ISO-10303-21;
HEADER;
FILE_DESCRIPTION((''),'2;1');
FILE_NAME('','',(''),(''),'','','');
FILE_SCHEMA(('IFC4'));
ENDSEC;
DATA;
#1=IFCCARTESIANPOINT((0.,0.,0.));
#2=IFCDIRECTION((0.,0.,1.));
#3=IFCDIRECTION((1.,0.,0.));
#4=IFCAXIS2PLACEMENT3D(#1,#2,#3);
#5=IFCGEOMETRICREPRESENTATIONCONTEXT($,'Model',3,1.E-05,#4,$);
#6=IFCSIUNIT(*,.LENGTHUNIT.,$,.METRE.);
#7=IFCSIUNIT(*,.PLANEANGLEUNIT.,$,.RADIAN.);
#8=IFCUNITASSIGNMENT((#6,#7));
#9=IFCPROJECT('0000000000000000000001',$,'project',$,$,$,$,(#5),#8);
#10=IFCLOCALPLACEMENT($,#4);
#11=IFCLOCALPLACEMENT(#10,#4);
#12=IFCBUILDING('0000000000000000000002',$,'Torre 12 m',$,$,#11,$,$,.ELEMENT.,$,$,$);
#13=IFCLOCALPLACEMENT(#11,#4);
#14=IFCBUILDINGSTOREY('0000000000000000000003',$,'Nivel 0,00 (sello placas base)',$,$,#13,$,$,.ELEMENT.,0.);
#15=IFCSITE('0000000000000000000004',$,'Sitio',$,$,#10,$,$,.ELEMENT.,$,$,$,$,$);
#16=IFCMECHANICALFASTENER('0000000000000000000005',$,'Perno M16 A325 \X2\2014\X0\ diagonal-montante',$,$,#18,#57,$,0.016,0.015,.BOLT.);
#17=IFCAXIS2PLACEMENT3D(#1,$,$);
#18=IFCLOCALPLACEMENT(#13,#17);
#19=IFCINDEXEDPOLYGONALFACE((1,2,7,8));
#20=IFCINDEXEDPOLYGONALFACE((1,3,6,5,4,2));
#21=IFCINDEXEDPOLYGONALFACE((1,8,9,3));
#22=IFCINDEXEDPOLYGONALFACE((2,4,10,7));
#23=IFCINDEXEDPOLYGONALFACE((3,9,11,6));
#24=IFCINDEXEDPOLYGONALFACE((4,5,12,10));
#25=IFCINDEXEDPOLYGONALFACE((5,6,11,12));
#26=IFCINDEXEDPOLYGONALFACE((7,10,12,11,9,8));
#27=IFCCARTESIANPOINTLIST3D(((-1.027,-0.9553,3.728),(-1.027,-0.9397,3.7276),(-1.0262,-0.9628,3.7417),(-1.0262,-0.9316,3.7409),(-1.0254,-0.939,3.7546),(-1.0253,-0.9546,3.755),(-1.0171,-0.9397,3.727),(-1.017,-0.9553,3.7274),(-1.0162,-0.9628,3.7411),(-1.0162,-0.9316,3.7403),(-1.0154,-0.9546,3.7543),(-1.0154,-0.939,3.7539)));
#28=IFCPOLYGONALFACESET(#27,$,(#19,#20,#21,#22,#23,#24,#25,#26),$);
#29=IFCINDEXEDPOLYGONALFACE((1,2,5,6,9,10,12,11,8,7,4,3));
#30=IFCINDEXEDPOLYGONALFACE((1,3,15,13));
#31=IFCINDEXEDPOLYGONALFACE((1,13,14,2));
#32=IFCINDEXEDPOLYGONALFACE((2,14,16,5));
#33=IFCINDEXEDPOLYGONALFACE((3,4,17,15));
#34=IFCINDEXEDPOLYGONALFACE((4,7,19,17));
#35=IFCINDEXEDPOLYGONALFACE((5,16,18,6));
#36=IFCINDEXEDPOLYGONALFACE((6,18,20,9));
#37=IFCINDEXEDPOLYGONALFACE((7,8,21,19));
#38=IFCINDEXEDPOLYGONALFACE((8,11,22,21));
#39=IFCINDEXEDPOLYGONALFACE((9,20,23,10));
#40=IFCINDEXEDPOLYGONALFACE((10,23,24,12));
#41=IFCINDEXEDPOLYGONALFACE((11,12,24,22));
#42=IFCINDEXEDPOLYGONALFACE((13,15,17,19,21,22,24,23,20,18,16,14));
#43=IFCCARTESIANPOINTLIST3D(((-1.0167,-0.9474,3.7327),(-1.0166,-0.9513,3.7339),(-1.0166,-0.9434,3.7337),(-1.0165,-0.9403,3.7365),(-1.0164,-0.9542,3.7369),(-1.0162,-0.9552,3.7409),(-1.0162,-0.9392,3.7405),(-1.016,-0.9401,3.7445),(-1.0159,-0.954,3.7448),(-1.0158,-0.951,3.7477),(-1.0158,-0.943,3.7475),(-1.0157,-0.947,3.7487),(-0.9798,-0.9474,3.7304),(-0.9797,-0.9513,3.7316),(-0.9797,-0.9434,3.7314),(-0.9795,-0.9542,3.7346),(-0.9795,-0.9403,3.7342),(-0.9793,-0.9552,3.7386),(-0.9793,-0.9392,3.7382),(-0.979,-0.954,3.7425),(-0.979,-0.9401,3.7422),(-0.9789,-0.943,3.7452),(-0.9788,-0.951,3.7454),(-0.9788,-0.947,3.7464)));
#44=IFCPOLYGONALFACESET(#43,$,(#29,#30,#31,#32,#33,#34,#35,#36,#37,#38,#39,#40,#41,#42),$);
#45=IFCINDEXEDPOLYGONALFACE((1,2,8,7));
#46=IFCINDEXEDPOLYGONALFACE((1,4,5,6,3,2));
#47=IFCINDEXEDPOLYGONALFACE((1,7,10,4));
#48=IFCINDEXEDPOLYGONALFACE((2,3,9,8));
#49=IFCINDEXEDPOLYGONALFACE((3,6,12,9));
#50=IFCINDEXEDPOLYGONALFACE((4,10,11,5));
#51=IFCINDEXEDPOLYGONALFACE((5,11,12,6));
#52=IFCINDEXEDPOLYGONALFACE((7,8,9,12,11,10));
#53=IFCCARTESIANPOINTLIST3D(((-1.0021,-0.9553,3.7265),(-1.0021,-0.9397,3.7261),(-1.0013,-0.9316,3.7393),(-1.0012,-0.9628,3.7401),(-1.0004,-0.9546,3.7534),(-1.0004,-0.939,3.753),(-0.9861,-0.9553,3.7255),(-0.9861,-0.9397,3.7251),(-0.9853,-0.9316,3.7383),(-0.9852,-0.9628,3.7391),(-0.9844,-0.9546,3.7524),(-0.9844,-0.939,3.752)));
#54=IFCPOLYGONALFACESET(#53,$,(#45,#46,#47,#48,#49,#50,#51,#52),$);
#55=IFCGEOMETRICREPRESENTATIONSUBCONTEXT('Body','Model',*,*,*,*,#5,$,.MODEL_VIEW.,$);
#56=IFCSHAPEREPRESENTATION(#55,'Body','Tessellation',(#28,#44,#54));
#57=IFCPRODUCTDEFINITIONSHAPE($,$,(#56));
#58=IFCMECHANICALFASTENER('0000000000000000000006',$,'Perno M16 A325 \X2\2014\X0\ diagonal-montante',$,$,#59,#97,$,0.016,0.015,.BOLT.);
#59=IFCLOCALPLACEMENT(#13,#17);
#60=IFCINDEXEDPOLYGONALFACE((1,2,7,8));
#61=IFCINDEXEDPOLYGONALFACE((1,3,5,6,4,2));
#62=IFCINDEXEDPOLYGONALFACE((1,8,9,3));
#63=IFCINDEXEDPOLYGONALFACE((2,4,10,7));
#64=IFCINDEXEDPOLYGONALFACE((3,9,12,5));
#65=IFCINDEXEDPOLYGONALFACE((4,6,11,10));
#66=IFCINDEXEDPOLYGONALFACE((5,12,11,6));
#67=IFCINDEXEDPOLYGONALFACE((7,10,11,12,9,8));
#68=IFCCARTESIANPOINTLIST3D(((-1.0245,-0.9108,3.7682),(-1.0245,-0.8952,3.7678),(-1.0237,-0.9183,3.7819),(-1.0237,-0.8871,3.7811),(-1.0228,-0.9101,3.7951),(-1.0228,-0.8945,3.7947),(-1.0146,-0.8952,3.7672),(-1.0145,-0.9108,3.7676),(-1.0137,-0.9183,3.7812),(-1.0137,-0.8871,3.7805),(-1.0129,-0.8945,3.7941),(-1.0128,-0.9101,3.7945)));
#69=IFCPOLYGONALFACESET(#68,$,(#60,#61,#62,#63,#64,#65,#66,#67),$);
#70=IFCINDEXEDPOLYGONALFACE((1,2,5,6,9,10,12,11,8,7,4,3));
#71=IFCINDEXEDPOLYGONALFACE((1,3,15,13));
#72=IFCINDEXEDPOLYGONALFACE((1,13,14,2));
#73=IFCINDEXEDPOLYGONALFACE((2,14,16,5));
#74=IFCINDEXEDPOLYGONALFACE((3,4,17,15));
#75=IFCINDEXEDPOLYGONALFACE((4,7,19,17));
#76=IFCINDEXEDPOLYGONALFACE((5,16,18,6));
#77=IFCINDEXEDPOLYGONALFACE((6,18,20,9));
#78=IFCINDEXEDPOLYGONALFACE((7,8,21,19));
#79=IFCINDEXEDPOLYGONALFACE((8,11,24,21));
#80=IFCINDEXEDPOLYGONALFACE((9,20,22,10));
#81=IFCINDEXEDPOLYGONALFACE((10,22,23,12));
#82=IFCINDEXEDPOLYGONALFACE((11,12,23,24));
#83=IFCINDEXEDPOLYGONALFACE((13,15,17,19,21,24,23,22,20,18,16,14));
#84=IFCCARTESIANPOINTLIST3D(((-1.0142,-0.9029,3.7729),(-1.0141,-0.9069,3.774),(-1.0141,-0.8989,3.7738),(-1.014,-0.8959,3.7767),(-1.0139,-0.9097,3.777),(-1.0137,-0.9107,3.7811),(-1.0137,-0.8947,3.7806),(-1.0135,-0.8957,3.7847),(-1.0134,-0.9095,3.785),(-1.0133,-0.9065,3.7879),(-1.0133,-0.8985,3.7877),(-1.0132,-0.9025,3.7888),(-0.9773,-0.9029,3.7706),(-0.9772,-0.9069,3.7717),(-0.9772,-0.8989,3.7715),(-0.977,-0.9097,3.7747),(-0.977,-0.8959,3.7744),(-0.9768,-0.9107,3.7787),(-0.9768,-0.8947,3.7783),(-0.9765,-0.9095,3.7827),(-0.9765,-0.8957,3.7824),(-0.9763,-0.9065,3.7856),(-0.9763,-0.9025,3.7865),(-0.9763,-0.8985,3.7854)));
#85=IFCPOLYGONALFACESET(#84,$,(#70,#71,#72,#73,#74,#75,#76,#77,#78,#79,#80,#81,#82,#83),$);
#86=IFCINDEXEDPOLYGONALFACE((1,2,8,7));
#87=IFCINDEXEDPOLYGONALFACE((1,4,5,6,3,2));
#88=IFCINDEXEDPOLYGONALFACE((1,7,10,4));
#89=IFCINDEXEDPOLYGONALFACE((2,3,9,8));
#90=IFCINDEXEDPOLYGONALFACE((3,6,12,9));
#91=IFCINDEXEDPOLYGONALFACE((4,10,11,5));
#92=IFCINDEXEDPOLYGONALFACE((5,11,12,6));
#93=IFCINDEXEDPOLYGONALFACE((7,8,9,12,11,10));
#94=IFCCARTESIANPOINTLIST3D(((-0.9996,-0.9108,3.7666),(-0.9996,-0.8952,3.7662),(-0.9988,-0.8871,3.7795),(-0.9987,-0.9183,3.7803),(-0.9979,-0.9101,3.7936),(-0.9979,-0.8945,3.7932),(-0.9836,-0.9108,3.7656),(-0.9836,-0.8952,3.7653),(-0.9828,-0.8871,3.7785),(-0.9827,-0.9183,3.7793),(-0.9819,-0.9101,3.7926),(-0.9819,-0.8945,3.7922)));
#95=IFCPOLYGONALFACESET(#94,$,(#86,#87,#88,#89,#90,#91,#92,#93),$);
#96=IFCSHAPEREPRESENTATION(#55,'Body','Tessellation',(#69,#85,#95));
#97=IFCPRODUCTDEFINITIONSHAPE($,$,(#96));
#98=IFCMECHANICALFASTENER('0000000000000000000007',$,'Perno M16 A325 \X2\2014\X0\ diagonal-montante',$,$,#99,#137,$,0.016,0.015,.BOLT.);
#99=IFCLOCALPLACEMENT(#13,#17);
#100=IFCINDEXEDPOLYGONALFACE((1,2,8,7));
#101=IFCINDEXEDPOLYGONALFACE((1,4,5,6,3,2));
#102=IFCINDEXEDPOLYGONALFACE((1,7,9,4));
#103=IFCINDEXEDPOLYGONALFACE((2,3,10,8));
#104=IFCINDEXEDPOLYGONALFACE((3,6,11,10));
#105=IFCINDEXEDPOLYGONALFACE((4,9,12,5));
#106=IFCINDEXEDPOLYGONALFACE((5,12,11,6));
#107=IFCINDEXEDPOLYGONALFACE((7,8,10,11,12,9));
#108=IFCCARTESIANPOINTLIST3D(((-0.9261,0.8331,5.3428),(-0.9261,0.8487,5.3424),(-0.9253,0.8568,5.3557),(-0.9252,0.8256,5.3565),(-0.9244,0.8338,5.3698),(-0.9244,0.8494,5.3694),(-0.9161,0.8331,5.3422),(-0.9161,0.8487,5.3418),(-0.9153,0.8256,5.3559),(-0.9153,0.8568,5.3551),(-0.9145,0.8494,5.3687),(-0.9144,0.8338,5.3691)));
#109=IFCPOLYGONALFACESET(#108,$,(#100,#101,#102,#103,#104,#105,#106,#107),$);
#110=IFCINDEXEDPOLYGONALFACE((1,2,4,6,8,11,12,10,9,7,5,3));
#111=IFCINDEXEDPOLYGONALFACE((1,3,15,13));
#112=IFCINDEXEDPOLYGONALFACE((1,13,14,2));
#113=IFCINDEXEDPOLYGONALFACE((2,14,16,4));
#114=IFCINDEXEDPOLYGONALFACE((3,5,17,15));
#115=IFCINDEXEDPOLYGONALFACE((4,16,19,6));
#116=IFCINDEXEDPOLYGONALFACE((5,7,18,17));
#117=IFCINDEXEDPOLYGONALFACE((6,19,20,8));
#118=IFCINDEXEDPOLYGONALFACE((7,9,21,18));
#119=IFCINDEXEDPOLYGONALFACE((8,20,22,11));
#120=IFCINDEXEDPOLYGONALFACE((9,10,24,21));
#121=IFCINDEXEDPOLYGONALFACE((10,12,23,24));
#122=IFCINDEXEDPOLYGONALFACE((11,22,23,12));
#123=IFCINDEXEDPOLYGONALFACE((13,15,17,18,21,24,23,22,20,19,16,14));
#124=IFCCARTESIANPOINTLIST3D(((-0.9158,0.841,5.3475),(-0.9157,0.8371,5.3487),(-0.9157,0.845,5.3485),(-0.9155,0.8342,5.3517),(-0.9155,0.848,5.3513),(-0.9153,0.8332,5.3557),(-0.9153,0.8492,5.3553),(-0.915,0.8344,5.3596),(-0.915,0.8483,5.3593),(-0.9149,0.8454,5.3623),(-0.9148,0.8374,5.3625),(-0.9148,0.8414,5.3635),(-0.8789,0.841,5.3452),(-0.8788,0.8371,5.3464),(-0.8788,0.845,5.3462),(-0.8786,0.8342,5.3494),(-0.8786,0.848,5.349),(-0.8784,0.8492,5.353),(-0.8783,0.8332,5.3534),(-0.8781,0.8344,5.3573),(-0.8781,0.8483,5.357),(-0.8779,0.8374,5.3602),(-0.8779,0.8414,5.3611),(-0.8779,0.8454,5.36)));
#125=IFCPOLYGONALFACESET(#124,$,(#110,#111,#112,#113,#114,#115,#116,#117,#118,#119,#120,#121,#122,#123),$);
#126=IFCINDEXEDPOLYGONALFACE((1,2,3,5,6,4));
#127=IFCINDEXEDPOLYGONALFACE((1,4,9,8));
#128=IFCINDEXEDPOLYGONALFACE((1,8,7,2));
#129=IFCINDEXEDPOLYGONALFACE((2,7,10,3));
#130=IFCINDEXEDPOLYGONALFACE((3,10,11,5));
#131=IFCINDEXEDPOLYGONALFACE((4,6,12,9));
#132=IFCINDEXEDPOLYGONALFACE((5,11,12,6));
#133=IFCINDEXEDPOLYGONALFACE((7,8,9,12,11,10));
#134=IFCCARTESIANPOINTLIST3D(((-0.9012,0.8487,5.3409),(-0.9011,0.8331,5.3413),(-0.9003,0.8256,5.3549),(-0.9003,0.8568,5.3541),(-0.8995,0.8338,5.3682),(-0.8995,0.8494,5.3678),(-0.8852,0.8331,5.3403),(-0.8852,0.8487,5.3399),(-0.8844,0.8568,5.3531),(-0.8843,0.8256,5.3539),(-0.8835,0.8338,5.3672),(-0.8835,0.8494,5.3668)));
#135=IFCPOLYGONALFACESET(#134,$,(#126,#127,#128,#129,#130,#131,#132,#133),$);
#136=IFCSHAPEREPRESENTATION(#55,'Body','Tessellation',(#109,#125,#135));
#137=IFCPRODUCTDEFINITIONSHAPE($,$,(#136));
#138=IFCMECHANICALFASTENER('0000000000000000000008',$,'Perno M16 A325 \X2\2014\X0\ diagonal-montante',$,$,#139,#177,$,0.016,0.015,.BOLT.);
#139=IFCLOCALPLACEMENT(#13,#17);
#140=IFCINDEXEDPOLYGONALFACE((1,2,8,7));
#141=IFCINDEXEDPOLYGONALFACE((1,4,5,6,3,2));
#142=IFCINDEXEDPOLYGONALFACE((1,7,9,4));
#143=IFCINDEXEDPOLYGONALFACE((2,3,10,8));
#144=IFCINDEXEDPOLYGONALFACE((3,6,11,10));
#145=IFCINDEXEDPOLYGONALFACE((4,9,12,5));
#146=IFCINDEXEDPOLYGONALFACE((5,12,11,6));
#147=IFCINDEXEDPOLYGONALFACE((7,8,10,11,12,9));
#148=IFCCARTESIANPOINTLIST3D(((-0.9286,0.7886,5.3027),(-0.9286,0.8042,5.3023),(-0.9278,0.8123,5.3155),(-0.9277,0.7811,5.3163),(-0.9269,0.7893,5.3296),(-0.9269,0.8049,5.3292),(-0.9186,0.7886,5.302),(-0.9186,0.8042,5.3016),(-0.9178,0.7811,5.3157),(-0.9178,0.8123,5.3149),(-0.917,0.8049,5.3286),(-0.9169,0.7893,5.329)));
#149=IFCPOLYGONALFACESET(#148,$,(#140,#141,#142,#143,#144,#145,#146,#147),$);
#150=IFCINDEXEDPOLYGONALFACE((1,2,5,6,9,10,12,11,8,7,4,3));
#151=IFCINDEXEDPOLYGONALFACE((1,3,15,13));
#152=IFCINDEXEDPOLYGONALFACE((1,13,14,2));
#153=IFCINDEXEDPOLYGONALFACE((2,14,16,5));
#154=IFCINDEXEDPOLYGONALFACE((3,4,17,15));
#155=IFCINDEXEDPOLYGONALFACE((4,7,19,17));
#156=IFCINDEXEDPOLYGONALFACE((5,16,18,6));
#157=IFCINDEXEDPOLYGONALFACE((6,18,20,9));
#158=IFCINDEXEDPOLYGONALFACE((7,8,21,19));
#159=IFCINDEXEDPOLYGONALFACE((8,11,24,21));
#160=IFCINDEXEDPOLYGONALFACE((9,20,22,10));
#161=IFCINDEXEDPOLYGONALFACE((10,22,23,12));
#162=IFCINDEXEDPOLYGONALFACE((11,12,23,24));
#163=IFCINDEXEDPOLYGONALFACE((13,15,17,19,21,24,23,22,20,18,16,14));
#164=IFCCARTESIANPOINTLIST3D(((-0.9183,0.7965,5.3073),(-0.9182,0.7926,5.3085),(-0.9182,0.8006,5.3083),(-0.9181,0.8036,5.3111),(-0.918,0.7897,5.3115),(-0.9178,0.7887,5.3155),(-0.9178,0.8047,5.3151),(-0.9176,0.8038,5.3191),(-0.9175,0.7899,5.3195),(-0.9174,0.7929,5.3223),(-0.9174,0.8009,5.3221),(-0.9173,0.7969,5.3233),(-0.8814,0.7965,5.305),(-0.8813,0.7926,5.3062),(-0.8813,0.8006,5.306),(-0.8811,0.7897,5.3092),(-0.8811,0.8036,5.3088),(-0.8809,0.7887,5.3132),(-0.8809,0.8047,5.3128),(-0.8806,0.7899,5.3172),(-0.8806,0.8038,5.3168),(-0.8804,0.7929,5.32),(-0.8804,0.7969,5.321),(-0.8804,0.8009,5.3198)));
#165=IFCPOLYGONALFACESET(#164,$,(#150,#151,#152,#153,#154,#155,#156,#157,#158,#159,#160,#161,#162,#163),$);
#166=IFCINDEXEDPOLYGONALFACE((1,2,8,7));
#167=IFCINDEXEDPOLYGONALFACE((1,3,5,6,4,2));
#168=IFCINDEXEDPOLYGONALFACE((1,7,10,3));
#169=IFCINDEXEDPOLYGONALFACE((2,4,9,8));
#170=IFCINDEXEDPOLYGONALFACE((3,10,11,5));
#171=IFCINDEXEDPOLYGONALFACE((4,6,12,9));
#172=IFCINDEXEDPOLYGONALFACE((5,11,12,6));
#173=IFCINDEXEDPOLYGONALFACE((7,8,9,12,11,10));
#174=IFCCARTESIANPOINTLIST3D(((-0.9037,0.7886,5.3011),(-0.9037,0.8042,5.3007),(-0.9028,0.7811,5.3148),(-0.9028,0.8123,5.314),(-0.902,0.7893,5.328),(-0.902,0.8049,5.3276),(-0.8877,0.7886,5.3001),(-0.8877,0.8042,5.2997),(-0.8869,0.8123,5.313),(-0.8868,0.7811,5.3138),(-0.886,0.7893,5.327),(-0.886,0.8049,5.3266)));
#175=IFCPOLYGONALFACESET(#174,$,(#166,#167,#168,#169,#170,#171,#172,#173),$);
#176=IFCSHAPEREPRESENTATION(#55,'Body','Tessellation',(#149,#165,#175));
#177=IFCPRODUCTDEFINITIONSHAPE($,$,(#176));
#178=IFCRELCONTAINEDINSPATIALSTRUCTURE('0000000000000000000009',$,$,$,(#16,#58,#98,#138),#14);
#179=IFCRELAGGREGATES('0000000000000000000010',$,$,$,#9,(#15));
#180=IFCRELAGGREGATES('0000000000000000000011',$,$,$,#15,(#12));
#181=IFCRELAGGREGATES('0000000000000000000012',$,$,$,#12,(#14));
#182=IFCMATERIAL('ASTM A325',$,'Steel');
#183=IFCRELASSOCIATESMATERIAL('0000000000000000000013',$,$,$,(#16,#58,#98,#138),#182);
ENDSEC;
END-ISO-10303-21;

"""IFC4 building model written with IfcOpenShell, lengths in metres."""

from ifc_helpers import new_model, si_unit, frame, origin_with_axes, place, context, subcontext, project, spatial, polyline, outline, extrude, material, element, save


model = new_model("IFC4")

# Units and contexts
model_context = context("Model", 3, precision=1e-05, world=origin_with_axes())
body_context = subcontext(model_context, "Body", "Model", "MODEL_VIEW")
ifc_project = project(units=[si_unit("LENGTHUNIT", "METRE"), si_unit("PLANEANGLEUNIT", "RADIAN")], contexts=[model_context])

# Site, building, storey
site_placement = place(None, origin_with_axes())
site = spatial("IfcSite", under=ifc_project, at=site_placement, Name="Sitio", CompositionType="ELEMENT")
building_placement = place(site_placement, origin_with_axes())
building = spatial("IfcBuilding", under=site, at=building_placement, Name="Torre 12 m", CompositionType="ELEMENT")
storey_placement = place(building_placement, origin_with_axes())
storey = spatial("IfcBuildingStorey", under=building, at=storey_placement, Name="Nivel 0,00 (sello placas base)", CompositionType="ELEMENT", Elevation=0.0)

# Shared definitions
placement = place(storey_placement, origin_with_axes())

# Mechanical fasteners
ifc_material_1 = material(Name="ASTM A325", Category="Steel")
element("IfcMechanicalFastener", 1, at=placement, inside=storey, material=ifc_material_1, Name="Perno M16 A325 — diagonal-montante", NominalDiameter=0.016, NominalLength=0.015, PredefinedType="BOLT", context=body_context, shape_type="SweptSolid", body=[
    extrude(outline(polyline([(0.0135, 0.0078), (0.0, 0.0156), (-0.0135, 0.0078), (-0.0135, -0.0078), (0.0, -0.0156), (0.0135, -0.0078), (0.0135, 0.0078)])), frame((-1.0262, -0.9472, 3.7413), z_axis=(0.998053, 0.0, -0.062378), x_axis=(0.032557, -0.85299, 0.52091)), (0.0, 0.0, 1.0), 0.01),
    extrude(outline(polyline([(0.008, 0.0), (0.0069, 0.004), (0.004, 0.0069), (0.0, 0.008), (-0.004, 0.0069), (-0.0069, 0.004), (-0.008, 0.0), (-0.0069, -0.004), (-0.004, -0.0069), (0.0, -0.008), (0.004, -0.0069), (0.0069, -0.004), (0.008, 0.0)])), frame((-1.0162, -0.9472, 3.7407), z_axis=(0.998053, 0.0, -0.062378), x_axis=(0.032557, -0.85299, 0.52091)), (0.0, 0.0, 1.0), 0.037),
    extrude(outline(polyline([(0.0135, 0.0078), (0.0, 0.0156), (-0.0135, 0.0078), (-0.0135, -0.0078), (0.0, -0.0156), (0.0135, -0.0078), (0.0135, 0.0078)])), frame((-1.0012, -0.9472, 3.7397), z_axis=(0.998053, 0.0, -0.062378), x_axis=(0.032557, -0.85299, 0.52091)), (0.0, 0.0, 1.0), 0.016),
])
element("IfcMechanicalFastener", 2, at=placement, inside=storey, material=ifc_material_1, Name="Perno M16 A325 — diagonal-montante", NominalDiameter=0.016, NominalLength=0.015, PredefinedType="BOLT", context=body_context, shape_type="SweptSolid", body=[
    extrude(outline(polyline([(0.0135, 0.0078), (0.0, 0.0156), (-0.0135, 0.0078), (-0.0135, -0.0078), (0.0, -0.0156), (0.0135, -0.0078), (0.0135, 0.0078)])), frame((-1.0237, -0.9027, 3.7815), z_axis=(0.998053, 0.0, -0.062378), x_axis=(0.032557, -0.85299, 0.52091)), (0.0, 0.0, 1.0), 0.01),
    extrude(outline(polyline([(0.008, 0.0), (0.0069, 0.004), (0.004, 0.0069), (0.0, 0.008), (-0.004, 0.0069), (-0.0069, 0.004), (-0.008, 0.0), (-0.0069, -0.004), (-0.004, -0.0069), (0.0, -0.008), (0.004, -0.0069), (0.0069, -0.004), (0.008, 0.0)])), frame((-1.0137, -0.9027, 3.7809), z_axis=(0.998053, 0.0, -0.062378), x_axis=(0.032557, -0.85299, 0.52091)), (0.0, 0.0, 1.0), 0.037),
    extrude(outline(polyline([(0.0135, 0.0078), (0.0, 0.0156), (-0.0135, 0.0078), (-0.0135, -0.0078), (0.0, -0.0156), (0.0135, -0.0078), (0.0135, 0.0078)])), frame((-0.9987, -0.9027, 3.7799), z_axis=(0.998053, 0.0, -0.062378), x_axis=(0.032557, -0.85299, 0.52091)), (0.0, 0.0, 1.0), 0.016),
])
element("IfcMechanicalFastener", 3, at=placement, inside=storey, material=ifc_material_1, Name="Perno M16 A325 — diagonal-montante", NominalDiameter=0.016, NominalLength=0.015, PredefinedType="BOLT", context=body_context, shape_type="SweptSolid", body=[
    extrude(outline(polyline([(0.0135, 0.0078), (0.0, 0.0156), (-0.0135, 0.0078), (-0.0135, -0.0078), (0.0, -0.0156), (0.0135, -0.0078), (0.0135, 0.0078)])), frame((-0.9253, 0.8412, 5.3561), z_axis=(0.998053, 0.0, -0.062378), x_axis=(0.032557, -0.85299, 0.52091)), (0.0, 0.0, 1.0), 0.01),
    extrude(outline(polyline([(0.008, 0.0), (0.0069, 0.004), (0.004, 0.0069), (0.0, 0.008), (-0.004, 0.0069), (-0.0069, 0.004), (-0.008, 0.0), (-0.0069, -0.004), (-0.004, -0.0069), (0.0, -0.008), (0.004, -0.0069), (0.0069, -0.004), (0.008, 0.0)])), frame((-0.9153, 0.8412, 5.3555), z_axis=(0.998053, 0.0, -0.062378), x_axis=(0.032557, -0.85299, 0.52091)), (0.0, 0.0, 1.0), 0.037),
    extrude(outline(polyline([(0.0135, 0.0078), (0.0, 0.0156), (-0.0135, 0.0078), (-0.0135, -0.0078), (0.0, -0.0156), (0.0135, -0.0078), (0.0135, 0.0078)])), frame((-0.9003, 0.8412, 5.3545), z_axis=(0.998053, 0.0, -0.062378), x_axis=(0.032557, -0.85299, 0.52091)), (0.0, 0.0, 1.0), 0.016),
])
element("IfcMechanicalFastener", 4, at=placement, inside=storey, material=ifc_material_1, Name="Perno M16 A325 — diagonal-montante", NominalDiameter=0.016, NominalLength=0.015, PredefinedType="BOLT", context=body_context, shape_type="SweptSolid", body=[
    extrude(outline(polyline([(0.0135, 0.0078), (0.0, 0.0156), (-0.0135, 0.0078), (-0.0135, -0.0078), (0.0, -0.0156), (0.0135, -0.0078), (0.0135, 0.0078)])), frame((-0.9278, 0.7967, 5.3159), z_axis=(0.998053, 0.0, -0.062378), x_axis=(0.032557, -0.85299, 0.52091)), (0.0, 0.0, 1.0), 0.01),
    extrude(outline(polyline([(0.008, 0.0), (0.0069, 0.004), (0.004, 0.0069), (0.0, 0.008), (-0.004, 0.0069), (-0.0069, 0.004), (-0.008, 0.0), (-0.0069, -0.004), (-0.004, -0.0069), (0.0, -0.008), (0.004, -0.0069), (0.0069, -0.004), (0.008, 0.0)])), frame((-0.9178, 0.7967, 5.3153), z_axis=(0.998053, 0.0, -0.062378), x_axis=(0.032557, -0.85299, 0.52091)), (0.0, 0.0, 1.0), 0.037),
    extrude(outline(polyline([(0.0135, 0.0078), (0.0, 0.0156), (-0.0135, 0.0078), (-0.0135, -0.0078), (0.0, -0.0156), (0.0135, -0.0078), (0.0135, 0.0078)])), frame((-0.9028, 0.7967, 5.3144), z_axis=(0.998053, 0.0, -0.062378), x_axis=(0.032557, -0.85299, 0.52091)), (0.0, 0.0, 1.0), 0.016),
])

save(model, "model.ifc")
